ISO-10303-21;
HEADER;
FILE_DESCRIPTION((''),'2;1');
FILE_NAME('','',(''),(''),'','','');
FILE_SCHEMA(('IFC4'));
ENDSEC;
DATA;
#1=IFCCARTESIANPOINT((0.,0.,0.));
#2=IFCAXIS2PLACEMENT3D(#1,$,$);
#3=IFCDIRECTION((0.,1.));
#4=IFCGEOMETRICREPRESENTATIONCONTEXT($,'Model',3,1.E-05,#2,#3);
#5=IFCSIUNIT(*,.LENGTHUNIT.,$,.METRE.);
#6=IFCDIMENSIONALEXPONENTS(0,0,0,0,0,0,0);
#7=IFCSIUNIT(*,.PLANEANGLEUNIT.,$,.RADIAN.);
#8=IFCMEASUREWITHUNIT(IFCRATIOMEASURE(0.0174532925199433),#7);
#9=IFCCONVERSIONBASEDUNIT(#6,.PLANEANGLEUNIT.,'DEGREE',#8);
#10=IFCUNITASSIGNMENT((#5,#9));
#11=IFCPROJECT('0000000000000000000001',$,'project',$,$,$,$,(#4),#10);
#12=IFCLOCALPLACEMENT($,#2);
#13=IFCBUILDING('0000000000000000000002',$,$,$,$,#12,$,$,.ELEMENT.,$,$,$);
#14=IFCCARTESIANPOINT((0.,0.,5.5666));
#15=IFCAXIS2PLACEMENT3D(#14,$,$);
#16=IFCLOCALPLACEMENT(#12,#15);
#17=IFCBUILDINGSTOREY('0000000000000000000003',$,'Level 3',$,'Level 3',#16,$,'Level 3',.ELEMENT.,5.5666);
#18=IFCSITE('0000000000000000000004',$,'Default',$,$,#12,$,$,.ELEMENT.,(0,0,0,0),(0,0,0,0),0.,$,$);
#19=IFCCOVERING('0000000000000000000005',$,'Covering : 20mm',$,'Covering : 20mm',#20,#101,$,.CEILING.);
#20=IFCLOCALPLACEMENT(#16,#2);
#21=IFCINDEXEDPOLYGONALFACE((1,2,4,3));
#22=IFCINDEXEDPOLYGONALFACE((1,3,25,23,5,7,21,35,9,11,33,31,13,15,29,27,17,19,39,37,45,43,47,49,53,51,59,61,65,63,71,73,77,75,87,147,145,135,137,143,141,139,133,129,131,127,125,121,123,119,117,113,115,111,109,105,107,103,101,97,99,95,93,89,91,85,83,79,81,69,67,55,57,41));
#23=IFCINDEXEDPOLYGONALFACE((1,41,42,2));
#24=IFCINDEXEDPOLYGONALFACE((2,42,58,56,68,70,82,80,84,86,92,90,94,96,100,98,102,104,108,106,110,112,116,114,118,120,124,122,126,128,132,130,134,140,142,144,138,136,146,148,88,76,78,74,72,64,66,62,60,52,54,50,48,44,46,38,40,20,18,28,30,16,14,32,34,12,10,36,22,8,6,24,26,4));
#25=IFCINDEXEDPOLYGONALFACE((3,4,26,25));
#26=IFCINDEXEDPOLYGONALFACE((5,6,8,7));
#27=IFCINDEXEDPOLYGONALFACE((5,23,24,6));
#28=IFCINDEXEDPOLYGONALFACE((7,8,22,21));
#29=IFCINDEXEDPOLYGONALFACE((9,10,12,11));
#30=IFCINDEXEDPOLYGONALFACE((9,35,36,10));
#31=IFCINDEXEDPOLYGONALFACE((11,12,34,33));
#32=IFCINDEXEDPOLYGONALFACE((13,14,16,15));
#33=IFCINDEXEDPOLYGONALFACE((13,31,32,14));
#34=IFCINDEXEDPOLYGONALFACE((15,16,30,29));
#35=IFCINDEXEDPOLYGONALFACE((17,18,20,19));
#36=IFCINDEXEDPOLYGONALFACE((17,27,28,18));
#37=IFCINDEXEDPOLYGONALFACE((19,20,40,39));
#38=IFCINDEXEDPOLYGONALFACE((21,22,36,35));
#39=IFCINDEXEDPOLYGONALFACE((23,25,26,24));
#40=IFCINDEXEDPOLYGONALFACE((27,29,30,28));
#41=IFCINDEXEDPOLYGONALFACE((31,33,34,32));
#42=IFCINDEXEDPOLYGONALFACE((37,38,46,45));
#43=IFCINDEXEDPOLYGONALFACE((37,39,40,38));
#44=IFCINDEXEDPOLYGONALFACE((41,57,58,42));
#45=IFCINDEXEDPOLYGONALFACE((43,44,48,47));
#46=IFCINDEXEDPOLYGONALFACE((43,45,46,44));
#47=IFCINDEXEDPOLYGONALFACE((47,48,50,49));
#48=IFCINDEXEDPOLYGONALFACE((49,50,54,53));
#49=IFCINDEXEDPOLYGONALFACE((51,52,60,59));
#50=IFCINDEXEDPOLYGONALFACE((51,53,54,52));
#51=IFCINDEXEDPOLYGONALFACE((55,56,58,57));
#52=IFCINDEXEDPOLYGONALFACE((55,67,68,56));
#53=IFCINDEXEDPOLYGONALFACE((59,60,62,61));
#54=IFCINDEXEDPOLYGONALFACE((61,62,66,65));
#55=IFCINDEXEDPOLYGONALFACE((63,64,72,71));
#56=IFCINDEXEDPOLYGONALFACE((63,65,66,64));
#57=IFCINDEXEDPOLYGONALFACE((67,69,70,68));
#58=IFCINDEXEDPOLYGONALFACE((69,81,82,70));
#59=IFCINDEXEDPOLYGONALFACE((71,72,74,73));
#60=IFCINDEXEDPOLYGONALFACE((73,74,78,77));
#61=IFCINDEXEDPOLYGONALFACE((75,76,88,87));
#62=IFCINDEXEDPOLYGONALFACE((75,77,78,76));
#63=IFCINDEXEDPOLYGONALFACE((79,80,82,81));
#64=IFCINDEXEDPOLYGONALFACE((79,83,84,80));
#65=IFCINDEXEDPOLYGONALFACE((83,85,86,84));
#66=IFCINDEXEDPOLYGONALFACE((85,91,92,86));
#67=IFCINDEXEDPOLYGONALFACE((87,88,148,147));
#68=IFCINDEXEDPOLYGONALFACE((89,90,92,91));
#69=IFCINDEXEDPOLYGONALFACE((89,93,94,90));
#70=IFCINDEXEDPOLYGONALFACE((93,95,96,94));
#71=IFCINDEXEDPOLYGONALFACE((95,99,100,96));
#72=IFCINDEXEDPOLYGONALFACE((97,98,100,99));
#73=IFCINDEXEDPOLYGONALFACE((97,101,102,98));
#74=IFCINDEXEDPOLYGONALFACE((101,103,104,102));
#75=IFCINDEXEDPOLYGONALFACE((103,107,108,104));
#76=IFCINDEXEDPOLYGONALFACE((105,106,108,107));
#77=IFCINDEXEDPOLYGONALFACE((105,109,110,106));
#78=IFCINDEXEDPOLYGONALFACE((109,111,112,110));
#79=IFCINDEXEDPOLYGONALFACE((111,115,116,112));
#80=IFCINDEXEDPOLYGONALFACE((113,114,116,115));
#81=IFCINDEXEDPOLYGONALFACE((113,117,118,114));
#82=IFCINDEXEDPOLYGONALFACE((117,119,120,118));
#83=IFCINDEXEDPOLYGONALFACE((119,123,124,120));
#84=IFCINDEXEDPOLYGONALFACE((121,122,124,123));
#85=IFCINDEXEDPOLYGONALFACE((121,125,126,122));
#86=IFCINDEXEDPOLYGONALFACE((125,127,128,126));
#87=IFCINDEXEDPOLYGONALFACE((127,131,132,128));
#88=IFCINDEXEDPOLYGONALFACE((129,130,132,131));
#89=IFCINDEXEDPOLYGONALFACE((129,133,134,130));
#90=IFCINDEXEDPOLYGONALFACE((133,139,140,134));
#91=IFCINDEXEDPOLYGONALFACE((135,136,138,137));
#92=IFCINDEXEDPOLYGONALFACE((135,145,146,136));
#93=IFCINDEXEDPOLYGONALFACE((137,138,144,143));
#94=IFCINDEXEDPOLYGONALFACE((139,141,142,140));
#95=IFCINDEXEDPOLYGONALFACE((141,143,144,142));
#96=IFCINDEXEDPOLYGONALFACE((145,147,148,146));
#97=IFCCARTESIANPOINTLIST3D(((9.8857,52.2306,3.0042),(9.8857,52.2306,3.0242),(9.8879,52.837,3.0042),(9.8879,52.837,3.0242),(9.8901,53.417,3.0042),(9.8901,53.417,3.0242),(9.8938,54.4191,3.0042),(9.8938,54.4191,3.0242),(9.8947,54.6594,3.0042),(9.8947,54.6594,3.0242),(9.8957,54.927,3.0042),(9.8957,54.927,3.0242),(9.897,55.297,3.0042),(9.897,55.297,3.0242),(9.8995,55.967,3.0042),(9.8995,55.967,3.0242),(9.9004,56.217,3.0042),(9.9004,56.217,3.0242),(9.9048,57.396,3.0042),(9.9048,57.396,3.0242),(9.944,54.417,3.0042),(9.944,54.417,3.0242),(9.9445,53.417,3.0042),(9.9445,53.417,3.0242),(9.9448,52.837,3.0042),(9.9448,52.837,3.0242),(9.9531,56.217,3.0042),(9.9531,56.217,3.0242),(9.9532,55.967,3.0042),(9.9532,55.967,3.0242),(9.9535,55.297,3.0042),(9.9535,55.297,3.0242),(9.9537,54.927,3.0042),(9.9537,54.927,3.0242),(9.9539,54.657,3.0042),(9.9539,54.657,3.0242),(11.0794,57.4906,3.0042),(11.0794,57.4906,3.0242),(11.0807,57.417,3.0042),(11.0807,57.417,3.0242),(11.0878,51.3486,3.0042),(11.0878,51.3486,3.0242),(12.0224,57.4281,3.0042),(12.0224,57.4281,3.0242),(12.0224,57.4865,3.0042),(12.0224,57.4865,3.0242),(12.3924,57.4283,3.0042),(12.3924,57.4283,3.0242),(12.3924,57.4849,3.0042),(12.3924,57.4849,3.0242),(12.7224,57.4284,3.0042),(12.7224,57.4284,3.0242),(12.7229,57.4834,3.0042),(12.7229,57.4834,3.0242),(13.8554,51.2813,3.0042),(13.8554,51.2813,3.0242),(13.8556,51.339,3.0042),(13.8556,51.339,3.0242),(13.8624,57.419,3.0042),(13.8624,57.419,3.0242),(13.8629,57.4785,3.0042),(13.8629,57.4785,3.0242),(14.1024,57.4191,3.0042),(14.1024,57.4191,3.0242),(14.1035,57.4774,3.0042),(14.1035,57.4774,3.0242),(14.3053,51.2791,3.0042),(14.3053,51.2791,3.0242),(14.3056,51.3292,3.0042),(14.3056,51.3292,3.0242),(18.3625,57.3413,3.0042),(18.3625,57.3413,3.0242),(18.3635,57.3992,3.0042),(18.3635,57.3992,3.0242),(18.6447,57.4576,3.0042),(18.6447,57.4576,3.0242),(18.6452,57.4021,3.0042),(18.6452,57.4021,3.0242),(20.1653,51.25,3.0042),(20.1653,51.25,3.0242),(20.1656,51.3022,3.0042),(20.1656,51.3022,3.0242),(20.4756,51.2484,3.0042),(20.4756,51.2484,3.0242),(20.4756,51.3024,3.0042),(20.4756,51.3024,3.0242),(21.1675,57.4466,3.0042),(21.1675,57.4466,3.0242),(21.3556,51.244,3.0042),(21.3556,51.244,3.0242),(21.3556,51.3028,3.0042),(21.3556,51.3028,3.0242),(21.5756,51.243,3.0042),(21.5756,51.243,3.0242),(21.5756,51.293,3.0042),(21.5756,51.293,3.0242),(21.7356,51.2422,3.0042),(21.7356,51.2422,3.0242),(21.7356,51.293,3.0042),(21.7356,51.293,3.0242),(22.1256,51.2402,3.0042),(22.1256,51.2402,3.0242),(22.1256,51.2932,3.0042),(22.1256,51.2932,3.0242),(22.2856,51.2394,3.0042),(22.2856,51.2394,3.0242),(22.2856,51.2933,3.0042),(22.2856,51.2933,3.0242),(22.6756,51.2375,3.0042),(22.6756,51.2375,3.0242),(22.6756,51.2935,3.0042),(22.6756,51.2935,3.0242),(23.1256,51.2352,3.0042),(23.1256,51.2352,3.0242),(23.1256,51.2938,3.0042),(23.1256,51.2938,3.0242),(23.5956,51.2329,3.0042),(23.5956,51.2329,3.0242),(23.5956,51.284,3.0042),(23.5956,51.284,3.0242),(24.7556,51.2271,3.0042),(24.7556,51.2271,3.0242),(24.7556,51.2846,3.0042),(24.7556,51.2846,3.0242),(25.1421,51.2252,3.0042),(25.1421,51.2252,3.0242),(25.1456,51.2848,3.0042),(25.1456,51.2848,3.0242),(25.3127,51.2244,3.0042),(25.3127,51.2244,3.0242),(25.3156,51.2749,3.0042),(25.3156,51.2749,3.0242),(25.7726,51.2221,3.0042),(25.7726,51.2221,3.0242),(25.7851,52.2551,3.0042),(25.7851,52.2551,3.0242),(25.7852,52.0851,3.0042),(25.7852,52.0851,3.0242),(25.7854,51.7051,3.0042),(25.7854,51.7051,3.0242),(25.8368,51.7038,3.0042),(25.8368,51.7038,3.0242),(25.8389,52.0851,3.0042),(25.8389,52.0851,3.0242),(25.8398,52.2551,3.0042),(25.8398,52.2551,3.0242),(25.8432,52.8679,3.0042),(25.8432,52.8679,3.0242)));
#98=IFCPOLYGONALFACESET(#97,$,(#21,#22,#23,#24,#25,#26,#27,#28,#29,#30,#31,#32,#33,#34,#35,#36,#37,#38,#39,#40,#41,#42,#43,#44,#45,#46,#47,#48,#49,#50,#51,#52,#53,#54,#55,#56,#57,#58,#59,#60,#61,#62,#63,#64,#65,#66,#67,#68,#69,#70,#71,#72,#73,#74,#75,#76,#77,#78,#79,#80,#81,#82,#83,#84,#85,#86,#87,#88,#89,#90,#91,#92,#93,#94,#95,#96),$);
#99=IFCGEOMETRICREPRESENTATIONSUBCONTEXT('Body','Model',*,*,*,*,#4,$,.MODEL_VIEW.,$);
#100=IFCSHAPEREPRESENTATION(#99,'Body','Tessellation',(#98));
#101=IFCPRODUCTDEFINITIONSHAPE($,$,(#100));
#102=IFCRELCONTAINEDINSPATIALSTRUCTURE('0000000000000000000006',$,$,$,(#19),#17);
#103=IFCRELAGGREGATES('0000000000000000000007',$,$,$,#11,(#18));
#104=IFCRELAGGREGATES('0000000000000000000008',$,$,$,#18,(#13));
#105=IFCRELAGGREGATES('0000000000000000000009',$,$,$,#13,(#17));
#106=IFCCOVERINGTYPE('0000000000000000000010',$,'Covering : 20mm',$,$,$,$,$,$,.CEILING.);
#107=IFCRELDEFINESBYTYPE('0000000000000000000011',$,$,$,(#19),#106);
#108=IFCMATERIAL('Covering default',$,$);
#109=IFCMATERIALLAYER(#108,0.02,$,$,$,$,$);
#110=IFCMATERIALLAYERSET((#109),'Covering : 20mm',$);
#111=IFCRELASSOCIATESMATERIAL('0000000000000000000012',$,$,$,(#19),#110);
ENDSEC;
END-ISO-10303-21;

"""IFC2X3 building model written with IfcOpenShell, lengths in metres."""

from ifc_helpers import new_model, entity, si_unit, converted_unit, direction, frame, origin, origin_with_axes, place, context, subcontext, project, spatial, polyline, outline, extrude, material, layer, layer_set, layer_usage, type_object, element, save


model = new_model("IFC2X3")

# Units and contexts
model_context = context("Model", 3, precision=1e-05, world=origin(), true_north=direction((0.0, 1.0)))
body_context = subcontext(model_context, "Body", "Model", "MODEL_VIEW")
ifc_project = project(units=[si_unit("LENGTHUNIT", "METRE"), converted_unit("PLANEANGLEUNIT", "DEGREE", entity("IfcRatioMeasure", 0.0174532925199433), si_unit("PLANEANGLEUNIT", "RADIAN"), dimensions=[0, 0, 0, 0, 0, 0, 0])], contexts=[model_context])

# Site, building, storey
placement = place(None, origin())
site = spatial("IfcSite", under=ifc_project, at=placement, Name="Default", CompositionType="ELEMENT", RefLatitude=(0, 0, 0, 0), RefLongitude=(0, 0, 0, 0), RefElevation=0.0)
building = spatial("IfcBuilding", under=site, at=placement, CompositionType="ELEMENT")
storey_placement = place(placement, frame((0.0, 0.0, 5.5666)))
storey = spatial("IfcBuildingStorey", under=building, at=storey_placement, Name="Level 3", ObjectType="Level 3", LongName="Level 3", CompositionType="ELEMENT", Elevation=5.5666)

# Covering
ifc_material_1 = material(Name="Covering default")
ifc_layer_1 = layer(ifc_material_1, 0.02)
ifc_layer_set_1 = layer_set([ifc_layer_1], Name="Covering : 20mm")
ifc_layer_usage_1 = layer_usage(ifc_layer_set_1, "AXIS3", "POSITIVE", 0.0)
covering_type_1 = type_object("IfcCoveringType", Name="Covering : 20mm", PredefinedType="CEILING")
covering_1_placement = place(placement, frame((0.0, 0.0, 8.5708)))
element("IfcCovering", 1, at=covering_1_placement, inside=storey, type_object=covering_type_1, material=ifc_layer_usage_1, Name="Covering : 20mm", ObjectType="Covering : 20mm", PredefinedType="CEILING", context=body_context, shape_type="SweptSolid", body=[
    extrude(outline(polyline([(11.0878, 51.3486), (13.8556, 51.339), (13.8554, 51.2813), (14.3053, 51.2791), (14.3056, 51.3292), (20.1656, 51.3022), (20.1653, 51.25), (20.4756, 51.2484), (20.4756, 51.3024), (21.3556, 51.3028), (21.3556, 51.244), (21.5756, 51.243), (21.5756, 51.293), (21.7356, 51.293), (21.7356, 51.2422), (22.1256, 51.2402), (22.1256, 51.2932), (22.2856, 51.2933), (22.2856, 51.2394), (22.6756, 51.2375), (22.6756, 51.2935), (23.1256, 51.2938), (23.1256, 51.2352), (23.5956, 51.2329), (23.5956, 51.284), (24.7556, 51.2846), (24.7556, 51.2271), (25.1421, 51.2252), (25.1456, 51.2848), (25.3156, 51.2749), (25.3127, 51.2244), (25.7726, 51.2221), (25.7854, 51.7051), (25.8368, 51.7038), (25.8389, 52.0851), (25.7852, 52.0851), (25.7851, 52.2551), (25.8398, 52.2551), (25.8432, 52.8679), (21.1675, 57.4466), (18.6447, 57.4576), (18.6452, 57.4021), (18.3635, 57.3992), (18.3625, 57.3413), (14.1024, 57.4191), (14.1035, 57.4774), (13.8629, 57.4785), (13.8624, 57.419), (12.7224, 57.4284), (12.7229, 57.4834), (12.3924, 57.4849), (12.3924, 57.4283), (12.0224, 57.4281), (12.0224, 57.4865), (11.0794, 57.4906), (11.0807, 57.417), (9.9048, 57.396), (9.9004, 56.217), (9.9531, 56.217), (9.9532, 55.967), (9.8995, 55.967), (9.897, 55.297), (9.9535, 55.297), (9.9537, 54.927), (9.8957, 54.927), (9.8947, 54.6594), (9.9539, 54.657), (9.944, 54.417), (9.8938, 54.4191), (9.8901, 53.417), (9.9445, 53.417), (9.9448, 52.837), (9.8879, 52.837), (9.8857, 52.2306), (11.0878, 51.3486)])), origin_with_axes(), (0.0, 0.0, 1.0), 0.02),
])

save(model, "model.ifc")
